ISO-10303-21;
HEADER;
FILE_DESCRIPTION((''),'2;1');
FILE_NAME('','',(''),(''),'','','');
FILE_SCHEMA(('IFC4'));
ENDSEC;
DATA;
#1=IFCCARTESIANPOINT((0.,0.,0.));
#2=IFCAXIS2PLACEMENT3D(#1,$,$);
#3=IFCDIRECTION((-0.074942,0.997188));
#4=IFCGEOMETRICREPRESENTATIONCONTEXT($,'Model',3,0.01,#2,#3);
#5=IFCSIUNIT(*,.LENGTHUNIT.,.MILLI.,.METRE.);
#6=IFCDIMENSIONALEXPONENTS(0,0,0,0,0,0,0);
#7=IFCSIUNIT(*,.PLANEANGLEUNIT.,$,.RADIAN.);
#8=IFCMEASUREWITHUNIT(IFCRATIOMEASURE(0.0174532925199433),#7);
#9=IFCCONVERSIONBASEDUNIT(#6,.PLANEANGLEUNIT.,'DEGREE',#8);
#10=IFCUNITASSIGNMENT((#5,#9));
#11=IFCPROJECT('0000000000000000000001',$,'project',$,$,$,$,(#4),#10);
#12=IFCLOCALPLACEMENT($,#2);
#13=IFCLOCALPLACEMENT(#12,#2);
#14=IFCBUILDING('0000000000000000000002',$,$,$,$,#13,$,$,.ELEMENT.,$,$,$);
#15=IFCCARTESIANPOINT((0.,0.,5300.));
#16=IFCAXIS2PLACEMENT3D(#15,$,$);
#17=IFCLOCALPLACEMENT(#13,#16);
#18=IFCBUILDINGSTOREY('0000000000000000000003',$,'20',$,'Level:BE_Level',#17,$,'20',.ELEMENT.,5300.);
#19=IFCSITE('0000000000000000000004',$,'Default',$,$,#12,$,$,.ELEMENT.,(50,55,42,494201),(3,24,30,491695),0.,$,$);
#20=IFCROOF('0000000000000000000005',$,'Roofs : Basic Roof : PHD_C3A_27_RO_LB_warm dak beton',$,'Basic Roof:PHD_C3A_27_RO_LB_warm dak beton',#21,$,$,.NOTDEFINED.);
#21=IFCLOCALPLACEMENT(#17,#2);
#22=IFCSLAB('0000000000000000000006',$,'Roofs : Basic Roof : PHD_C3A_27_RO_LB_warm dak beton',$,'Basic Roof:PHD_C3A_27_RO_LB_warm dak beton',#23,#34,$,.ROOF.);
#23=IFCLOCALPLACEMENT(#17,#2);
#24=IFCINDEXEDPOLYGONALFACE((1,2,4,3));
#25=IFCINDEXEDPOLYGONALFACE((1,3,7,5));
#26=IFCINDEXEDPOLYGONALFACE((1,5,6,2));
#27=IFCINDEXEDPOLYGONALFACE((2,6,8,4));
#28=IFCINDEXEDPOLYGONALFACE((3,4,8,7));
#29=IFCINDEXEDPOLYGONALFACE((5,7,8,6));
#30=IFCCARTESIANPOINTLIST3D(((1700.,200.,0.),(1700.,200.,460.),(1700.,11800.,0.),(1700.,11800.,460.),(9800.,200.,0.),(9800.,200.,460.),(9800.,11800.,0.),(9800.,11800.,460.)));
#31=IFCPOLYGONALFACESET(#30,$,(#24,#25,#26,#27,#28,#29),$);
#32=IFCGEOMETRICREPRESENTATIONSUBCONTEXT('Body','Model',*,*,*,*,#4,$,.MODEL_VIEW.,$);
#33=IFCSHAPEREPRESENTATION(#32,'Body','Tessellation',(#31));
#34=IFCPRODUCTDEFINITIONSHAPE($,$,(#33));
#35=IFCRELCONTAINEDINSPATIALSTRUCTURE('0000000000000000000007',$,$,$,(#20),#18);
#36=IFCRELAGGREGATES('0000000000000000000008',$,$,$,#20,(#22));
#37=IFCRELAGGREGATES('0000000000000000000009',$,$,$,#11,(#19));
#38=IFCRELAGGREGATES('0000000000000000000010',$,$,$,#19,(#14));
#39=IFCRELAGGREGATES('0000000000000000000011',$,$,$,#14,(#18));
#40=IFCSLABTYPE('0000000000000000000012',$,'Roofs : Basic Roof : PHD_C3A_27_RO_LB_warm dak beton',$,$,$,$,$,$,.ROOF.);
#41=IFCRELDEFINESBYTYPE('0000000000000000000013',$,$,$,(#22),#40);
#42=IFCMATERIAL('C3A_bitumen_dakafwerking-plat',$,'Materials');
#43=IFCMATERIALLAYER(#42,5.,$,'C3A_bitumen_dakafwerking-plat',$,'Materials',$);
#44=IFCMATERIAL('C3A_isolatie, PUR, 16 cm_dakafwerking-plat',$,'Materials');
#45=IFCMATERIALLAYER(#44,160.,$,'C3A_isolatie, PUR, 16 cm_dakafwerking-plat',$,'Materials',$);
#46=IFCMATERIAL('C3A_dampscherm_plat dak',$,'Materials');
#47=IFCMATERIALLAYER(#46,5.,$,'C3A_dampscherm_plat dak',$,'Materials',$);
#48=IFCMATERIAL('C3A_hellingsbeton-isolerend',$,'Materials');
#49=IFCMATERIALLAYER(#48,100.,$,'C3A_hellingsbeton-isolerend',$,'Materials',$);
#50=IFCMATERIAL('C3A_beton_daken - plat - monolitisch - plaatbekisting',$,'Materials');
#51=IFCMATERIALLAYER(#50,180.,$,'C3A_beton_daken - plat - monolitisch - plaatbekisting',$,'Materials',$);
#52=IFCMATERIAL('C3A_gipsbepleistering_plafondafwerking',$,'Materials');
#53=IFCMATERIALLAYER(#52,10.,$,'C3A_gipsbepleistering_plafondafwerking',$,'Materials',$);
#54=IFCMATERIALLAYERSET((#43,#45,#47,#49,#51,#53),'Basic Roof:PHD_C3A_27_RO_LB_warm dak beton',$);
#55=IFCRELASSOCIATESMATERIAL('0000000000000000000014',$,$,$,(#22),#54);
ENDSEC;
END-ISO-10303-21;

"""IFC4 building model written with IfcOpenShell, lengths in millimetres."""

from ifc_helpers import new_model, entity, si_unit, converted_unit, direction, frame, frame_2d, origin, place, context, subcontext, project, spatial, rectangle, extrude, material, layer, layer_set, type_object, element, aggregate, save


model = new_model("IFC4")

# Units and contexts
model_context = context("Model", 3, precision=0.01, world=origin(), true_north=direction((-0.074942, 0.997188)))
body_context = subcontext(model_context, "Body", "Model", "MODEL_VIEW")
ifc_project = project(units=[si_unit("LENGTHUNIT", "METRE", prefix="MILLI"), converted_unit("PLANEANGLEUNIT", "DEGREE", entity("IfcRatioMeasure", 0.0174532925199433), si_unit("PLANEANGLEUNIT", "RADIAN"), dimensions=[0, 0, 0, 0, 0, 0, 0])], contexts=[model_context])

# Site, building, storey
site_placement = place(None, origin())
site = spatial("IfcSite", under=ifc_project, at=site_placement, Name="Default", CompositionType="ELEMENT", RefLatitude=(50, 55, 42, 494201), RefLongitude=(3, 24, 30, 491695), RefElevation=0.0)
building_placement = place(site_placement, origin())
building = spatial("IfcBuilding", under=site, at=building_placement, CompositionType="ELEMENT")
storey_placement = place(building_placement, frame((0.0, 0.0, 5300.0)))
storey = spatial("IfcBuildingStorey", under=building, at=storey_placement, Name="20", ObjectType="Level:BE_Level", LongName="20", CompositionType="ELEMENT", Elevation=5300.0)

# Roof, slab
roof_placement = place(storey_placement, frame((1700.0, 200.0, 0.0)))
roof = element("IfcRoof", 1, at=roof_placement, inside=storey, Name="Roofs : Basic Roof : PHD_C3A_27_RO_LB_warm dak beton", ObjectType="Basic Roof:PHD_C3A_27_RO_LB_warm dak beton", PredefinedType="NOTDEFINED")
ifc_material_1 = material(Name="C3A_bitumen_dakafwerking-plat", Category="Materials")
ifc_layer_1 = layer(ifc_material_1, 5.0, Name="C3A_bitumen_dakafwerking-plat", Category="Materials")
ifc_material_2 = material(Name="C3A_isolatie, PUR, 16 cm_dakafwerking-plat", Category="Materials")
ifc_layer_2 = layer(ifc_material_2, 160.0, Name="C3A_isolatie, PUR, 16 cm_dakafwerking-plat", Category="Materials")
ifc_material_3 = material(Name="C3A_dampscherm_plat dak", Category="Materials")
ifc_layer_3 = layer(ifc_material_3, 5.0, Name="C3A_dampscherm_plat dak", Category="Materials")
ifc_material_4 = material(Name="C3A_hellingsbeton-isolerend", Category="Materials")
ifc_layer_4 = layer(ifc_material_4, 100.0, Name="C3A_hellingsbeton-isolerend", Category="Materials")
ifc_material_5 = material(Name="C3A_beton_daken - plat - monolitisch - plaatbekisting", Category="Materials")
ifc_layer_5 = layer(ifc_material_5, 180.0, Name="C3A_beton_daken - plat - monolitisch - plaatbekisting", Category="Materials")
ifc_material_6 = material(Name="C3A_gipsbepleistering_plafondafwerking", Category="Materials")
ifc_layer_6 = layer(ifc_material_6, 10.0, Name="C3A_gipsbepleistering_plafondafwerking", Category="Materials")
ifc_layer_set = layer_set([ifc_layer_1, ifc_layer_2, ifc_layer_3, ifc_layer_4, ifc_layer_5, ifc_layer_6], Name="Basic Roof:PHD_C3A_27_RO_LB_warm dak beton")
slab_type = type_object("IfcSlabType", Name="Roofs : Basic Roof : PHD_C3A_27_RO_LB_warm dak beton", PredefinedType="ROOF")
slab_placement = place(roof_placement, origin())
slab = element("IfcSlab", 2, at=slab_placement, type_object=slab_type, material=ifc_layer_set, Name="Roofs : Basic Roof : PHD_C3A_27_RO_LB_warm dak beton", ObjectType="Basic Roof:PHD_C3A_27_RO_LB_warm dak beton", PredefinedType="ROOF", context=body_context, shape_type="SweptSolid", body=[
    extrude(rectangle(XDim=8100.0, YDim=11600.0, at=frame_2d((0.0, 0.0), x_axis=(1.0, 0.0))), frame((4050.0, 5800.0, 0.0)), (0.0, 0.0, 1.0), 460.0),
])
aggregate(roof, [slab])

save(model, "model.ifc")
